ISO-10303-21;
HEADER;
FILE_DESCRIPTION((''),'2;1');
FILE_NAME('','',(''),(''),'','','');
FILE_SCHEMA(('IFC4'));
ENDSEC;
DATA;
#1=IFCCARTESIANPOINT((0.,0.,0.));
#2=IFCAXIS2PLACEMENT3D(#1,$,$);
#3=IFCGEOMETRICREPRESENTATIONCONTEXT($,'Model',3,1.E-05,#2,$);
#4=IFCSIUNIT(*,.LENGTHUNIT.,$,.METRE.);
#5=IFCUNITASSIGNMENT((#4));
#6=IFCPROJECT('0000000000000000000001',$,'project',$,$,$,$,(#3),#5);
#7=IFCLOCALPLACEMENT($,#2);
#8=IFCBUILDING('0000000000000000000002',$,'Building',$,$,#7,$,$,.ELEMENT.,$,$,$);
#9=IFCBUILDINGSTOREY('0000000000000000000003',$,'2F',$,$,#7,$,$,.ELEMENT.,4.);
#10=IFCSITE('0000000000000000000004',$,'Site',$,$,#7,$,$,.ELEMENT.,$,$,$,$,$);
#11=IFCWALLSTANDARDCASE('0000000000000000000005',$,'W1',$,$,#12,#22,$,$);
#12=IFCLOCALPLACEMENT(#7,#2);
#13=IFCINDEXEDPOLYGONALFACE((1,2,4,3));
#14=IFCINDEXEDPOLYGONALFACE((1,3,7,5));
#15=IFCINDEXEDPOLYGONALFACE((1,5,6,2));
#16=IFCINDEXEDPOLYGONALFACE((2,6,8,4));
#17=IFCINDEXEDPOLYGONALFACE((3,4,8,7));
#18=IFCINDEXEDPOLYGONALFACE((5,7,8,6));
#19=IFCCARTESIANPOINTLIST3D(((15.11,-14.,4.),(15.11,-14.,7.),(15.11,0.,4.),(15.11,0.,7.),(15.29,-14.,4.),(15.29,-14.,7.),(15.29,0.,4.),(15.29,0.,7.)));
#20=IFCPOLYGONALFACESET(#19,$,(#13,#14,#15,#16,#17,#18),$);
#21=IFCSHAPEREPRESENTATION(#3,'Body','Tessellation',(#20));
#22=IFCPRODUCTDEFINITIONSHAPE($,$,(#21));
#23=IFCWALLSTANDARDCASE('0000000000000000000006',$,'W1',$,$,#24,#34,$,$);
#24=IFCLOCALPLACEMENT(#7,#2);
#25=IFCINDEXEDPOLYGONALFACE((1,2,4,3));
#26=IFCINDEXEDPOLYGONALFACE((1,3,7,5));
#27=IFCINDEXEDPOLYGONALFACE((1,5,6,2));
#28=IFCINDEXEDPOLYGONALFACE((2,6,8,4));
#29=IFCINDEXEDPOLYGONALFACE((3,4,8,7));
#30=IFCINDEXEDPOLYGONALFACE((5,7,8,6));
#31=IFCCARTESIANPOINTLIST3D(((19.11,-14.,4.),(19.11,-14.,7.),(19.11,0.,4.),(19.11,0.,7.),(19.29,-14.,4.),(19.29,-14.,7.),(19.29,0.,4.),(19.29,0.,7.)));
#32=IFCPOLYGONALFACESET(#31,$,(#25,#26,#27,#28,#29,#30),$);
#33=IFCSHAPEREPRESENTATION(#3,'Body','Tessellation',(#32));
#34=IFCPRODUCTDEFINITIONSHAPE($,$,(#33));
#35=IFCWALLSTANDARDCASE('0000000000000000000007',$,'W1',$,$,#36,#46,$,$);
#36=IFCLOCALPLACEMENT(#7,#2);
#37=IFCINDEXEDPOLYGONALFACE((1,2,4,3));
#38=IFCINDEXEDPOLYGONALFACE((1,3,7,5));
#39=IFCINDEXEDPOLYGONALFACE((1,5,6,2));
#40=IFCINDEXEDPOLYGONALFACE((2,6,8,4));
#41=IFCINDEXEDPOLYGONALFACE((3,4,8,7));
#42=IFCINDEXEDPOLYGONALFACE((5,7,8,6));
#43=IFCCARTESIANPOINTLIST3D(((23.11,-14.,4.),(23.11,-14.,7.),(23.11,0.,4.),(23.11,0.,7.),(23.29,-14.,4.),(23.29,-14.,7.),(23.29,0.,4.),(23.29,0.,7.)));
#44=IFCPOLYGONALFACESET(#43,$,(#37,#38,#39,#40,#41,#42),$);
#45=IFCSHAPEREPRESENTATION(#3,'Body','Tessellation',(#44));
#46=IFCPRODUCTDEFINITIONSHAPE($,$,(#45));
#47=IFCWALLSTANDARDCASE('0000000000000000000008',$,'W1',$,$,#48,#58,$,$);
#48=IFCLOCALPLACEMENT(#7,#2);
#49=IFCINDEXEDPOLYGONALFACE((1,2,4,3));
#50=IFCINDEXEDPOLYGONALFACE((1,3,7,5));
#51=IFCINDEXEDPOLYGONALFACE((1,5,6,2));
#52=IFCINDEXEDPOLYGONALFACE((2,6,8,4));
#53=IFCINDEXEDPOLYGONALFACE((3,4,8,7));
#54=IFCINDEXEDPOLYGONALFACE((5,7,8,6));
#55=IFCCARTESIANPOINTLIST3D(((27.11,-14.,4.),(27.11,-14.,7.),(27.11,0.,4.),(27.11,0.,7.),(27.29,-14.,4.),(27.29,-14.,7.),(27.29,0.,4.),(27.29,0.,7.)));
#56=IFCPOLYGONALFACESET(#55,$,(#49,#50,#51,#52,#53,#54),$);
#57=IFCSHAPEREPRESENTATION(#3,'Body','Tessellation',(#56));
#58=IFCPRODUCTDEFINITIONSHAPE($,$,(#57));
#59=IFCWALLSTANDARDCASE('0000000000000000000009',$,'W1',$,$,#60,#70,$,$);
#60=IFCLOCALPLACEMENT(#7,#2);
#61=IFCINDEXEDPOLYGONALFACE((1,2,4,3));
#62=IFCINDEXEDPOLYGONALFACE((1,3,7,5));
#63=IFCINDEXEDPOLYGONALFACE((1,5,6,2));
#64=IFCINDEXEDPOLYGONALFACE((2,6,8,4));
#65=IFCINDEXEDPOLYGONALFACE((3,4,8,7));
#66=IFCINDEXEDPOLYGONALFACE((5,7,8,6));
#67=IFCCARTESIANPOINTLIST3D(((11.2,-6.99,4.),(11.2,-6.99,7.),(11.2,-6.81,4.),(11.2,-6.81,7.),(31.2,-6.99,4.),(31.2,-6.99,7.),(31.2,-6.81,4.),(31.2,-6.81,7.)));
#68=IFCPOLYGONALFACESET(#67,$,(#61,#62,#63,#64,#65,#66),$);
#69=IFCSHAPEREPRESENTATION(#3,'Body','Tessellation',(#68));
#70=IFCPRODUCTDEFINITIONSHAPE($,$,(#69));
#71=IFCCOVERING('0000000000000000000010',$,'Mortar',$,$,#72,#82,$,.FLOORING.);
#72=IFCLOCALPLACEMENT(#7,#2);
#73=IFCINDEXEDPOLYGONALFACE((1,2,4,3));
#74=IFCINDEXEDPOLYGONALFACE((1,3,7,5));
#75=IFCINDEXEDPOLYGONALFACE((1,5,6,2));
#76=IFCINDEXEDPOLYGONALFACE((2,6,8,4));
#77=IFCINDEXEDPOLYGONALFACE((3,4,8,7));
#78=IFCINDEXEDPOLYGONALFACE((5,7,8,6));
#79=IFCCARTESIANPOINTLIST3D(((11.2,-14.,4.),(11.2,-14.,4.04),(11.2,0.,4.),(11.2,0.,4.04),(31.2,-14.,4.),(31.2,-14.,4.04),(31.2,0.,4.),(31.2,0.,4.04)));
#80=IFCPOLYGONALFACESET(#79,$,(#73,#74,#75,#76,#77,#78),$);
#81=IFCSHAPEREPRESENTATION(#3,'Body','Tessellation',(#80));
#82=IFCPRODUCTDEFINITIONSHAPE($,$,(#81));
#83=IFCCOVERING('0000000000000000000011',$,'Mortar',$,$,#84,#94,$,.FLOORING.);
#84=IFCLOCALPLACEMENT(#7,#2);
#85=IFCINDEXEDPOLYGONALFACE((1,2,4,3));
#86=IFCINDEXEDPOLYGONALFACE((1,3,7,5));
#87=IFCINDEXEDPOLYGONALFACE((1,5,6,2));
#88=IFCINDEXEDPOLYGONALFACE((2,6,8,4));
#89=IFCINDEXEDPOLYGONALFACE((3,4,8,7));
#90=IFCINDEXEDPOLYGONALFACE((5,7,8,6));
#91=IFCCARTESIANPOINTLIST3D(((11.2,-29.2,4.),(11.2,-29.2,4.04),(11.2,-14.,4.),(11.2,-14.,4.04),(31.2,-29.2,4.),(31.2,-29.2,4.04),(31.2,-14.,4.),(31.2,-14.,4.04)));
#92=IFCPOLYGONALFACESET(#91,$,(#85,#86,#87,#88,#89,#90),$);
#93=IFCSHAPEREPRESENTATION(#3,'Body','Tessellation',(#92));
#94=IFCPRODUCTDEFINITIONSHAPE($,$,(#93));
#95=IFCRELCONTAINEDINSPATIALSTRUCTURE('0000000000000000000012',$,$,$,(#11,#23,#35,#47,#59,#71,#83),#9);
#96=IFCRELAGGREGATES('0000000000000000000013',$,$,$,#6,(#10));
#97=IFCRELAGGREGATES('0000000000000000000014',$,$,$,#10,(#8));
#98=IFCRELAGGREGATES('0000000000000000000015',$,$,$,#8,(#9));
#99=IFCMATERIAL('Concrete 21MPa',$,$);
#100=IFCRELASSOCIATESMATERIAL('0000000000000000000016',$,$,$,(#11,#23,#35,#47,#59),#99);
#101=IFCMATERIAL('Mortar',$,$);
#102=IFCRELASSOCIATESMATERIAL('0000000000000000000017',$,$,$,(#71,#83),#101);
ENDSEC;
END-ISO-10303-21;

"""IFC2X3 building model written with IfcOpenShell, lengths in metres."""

from ifc_helpers import new_model, si_unit, frame, origin, origin_2d, place, context, project, spatial, rectangle, extrude, material, element, save


model = new_model("IFC2X3")

# Units and contexts
model_context = context("Model", 3, precision=1e-05, world=origin())
ifc_project = project(units=[si_unit("LENGTHUNIT", "METRE")], contexts=[model_context])

# Site, building, storey
placement = place(None, origin())
site = spatial("IfcSite", under=ifc_project, at=placement, Name="Site", CompositionType="ELEMENT")
building = spatial("IfcBuilding", under=site, at=placement, Name="Building", CompositionType="ELEMENT")
storey = spatial("IfcBuildingStorey", under=building, at=placement, Name="2F", CompositionType="ELEMENT", Elevation=4.0)

# Shared definitions
ifc_material_1 = material(Name="Concrete 21MPa")

# Walls
for number, where, name in (
    (1, (15.2, -7.0, 4.0), "W1"),
    (2, (19.2, -7.0, 4.0), "W1"),
    (3, (23.2, -7.0, 4.0), "W1"),
    (4, (27.2, -7.0, 4.0), "W1"),
):
    element("IfcWallStandardCase", number, at=place(None, frame(where)), inside=storey, material=ifc_material_1, Name=name, context=model_context, shape_type="SweptSolid", body=[
        extrude(rectangle(XDim=0.18, YDim=14.0, at=origin_2d()), origin(), (0.0, 0.0, 1.0), 3.0),
    ])
wall_placement = place(None, frame((21.2, -6.9, 4.0)))
element("IfcWallStandardCase", 5, at=wall_placement, inside=storey, material=ifc_material_1, Name="W1", context=model_context, shape_type="SweptSolid", body=[
    extrude(rectangle(XDim=20.0, YDim=0.18, at=origin_2d()), origin(), (0.0, 0.0, 1.0), 3.0),
])

# Coverings
ifc_material_2 = material(Name="Mortar")
covering_1_placement = place(None, frame((21.2, -7.0, 4.0)))
element("IfcCovering", 6, at=covering_1_placement, inside=storey, material=ifc_material_2, Name="Mortar", PredefinedType="FLOORING", context=model_context, shape_type="SweptSolid", body=[
    extrude(rectangle(XDim=20.0, YDim=14.0, at=origin_2d()), origin(), (0.0, 0.0, 1.0), 0.04),
])
covering_2_placement = place(None, frame((21.2, -21.6, 4.0)))
element("IfcCovering", 7, at=covering_2_placement, inside=storey, material=ifc_material_2, Name="Mortar", PredefinedType="FLOORING", context=model_context, shape_type="SweptSolid", body=[
    extrude(rectangle(XDim=20.0, YDim=15.2, at=origin_2d()), origin(), (0.0, 0.0, 1.0), 0.04),
])

save(model, "model.ifc")
